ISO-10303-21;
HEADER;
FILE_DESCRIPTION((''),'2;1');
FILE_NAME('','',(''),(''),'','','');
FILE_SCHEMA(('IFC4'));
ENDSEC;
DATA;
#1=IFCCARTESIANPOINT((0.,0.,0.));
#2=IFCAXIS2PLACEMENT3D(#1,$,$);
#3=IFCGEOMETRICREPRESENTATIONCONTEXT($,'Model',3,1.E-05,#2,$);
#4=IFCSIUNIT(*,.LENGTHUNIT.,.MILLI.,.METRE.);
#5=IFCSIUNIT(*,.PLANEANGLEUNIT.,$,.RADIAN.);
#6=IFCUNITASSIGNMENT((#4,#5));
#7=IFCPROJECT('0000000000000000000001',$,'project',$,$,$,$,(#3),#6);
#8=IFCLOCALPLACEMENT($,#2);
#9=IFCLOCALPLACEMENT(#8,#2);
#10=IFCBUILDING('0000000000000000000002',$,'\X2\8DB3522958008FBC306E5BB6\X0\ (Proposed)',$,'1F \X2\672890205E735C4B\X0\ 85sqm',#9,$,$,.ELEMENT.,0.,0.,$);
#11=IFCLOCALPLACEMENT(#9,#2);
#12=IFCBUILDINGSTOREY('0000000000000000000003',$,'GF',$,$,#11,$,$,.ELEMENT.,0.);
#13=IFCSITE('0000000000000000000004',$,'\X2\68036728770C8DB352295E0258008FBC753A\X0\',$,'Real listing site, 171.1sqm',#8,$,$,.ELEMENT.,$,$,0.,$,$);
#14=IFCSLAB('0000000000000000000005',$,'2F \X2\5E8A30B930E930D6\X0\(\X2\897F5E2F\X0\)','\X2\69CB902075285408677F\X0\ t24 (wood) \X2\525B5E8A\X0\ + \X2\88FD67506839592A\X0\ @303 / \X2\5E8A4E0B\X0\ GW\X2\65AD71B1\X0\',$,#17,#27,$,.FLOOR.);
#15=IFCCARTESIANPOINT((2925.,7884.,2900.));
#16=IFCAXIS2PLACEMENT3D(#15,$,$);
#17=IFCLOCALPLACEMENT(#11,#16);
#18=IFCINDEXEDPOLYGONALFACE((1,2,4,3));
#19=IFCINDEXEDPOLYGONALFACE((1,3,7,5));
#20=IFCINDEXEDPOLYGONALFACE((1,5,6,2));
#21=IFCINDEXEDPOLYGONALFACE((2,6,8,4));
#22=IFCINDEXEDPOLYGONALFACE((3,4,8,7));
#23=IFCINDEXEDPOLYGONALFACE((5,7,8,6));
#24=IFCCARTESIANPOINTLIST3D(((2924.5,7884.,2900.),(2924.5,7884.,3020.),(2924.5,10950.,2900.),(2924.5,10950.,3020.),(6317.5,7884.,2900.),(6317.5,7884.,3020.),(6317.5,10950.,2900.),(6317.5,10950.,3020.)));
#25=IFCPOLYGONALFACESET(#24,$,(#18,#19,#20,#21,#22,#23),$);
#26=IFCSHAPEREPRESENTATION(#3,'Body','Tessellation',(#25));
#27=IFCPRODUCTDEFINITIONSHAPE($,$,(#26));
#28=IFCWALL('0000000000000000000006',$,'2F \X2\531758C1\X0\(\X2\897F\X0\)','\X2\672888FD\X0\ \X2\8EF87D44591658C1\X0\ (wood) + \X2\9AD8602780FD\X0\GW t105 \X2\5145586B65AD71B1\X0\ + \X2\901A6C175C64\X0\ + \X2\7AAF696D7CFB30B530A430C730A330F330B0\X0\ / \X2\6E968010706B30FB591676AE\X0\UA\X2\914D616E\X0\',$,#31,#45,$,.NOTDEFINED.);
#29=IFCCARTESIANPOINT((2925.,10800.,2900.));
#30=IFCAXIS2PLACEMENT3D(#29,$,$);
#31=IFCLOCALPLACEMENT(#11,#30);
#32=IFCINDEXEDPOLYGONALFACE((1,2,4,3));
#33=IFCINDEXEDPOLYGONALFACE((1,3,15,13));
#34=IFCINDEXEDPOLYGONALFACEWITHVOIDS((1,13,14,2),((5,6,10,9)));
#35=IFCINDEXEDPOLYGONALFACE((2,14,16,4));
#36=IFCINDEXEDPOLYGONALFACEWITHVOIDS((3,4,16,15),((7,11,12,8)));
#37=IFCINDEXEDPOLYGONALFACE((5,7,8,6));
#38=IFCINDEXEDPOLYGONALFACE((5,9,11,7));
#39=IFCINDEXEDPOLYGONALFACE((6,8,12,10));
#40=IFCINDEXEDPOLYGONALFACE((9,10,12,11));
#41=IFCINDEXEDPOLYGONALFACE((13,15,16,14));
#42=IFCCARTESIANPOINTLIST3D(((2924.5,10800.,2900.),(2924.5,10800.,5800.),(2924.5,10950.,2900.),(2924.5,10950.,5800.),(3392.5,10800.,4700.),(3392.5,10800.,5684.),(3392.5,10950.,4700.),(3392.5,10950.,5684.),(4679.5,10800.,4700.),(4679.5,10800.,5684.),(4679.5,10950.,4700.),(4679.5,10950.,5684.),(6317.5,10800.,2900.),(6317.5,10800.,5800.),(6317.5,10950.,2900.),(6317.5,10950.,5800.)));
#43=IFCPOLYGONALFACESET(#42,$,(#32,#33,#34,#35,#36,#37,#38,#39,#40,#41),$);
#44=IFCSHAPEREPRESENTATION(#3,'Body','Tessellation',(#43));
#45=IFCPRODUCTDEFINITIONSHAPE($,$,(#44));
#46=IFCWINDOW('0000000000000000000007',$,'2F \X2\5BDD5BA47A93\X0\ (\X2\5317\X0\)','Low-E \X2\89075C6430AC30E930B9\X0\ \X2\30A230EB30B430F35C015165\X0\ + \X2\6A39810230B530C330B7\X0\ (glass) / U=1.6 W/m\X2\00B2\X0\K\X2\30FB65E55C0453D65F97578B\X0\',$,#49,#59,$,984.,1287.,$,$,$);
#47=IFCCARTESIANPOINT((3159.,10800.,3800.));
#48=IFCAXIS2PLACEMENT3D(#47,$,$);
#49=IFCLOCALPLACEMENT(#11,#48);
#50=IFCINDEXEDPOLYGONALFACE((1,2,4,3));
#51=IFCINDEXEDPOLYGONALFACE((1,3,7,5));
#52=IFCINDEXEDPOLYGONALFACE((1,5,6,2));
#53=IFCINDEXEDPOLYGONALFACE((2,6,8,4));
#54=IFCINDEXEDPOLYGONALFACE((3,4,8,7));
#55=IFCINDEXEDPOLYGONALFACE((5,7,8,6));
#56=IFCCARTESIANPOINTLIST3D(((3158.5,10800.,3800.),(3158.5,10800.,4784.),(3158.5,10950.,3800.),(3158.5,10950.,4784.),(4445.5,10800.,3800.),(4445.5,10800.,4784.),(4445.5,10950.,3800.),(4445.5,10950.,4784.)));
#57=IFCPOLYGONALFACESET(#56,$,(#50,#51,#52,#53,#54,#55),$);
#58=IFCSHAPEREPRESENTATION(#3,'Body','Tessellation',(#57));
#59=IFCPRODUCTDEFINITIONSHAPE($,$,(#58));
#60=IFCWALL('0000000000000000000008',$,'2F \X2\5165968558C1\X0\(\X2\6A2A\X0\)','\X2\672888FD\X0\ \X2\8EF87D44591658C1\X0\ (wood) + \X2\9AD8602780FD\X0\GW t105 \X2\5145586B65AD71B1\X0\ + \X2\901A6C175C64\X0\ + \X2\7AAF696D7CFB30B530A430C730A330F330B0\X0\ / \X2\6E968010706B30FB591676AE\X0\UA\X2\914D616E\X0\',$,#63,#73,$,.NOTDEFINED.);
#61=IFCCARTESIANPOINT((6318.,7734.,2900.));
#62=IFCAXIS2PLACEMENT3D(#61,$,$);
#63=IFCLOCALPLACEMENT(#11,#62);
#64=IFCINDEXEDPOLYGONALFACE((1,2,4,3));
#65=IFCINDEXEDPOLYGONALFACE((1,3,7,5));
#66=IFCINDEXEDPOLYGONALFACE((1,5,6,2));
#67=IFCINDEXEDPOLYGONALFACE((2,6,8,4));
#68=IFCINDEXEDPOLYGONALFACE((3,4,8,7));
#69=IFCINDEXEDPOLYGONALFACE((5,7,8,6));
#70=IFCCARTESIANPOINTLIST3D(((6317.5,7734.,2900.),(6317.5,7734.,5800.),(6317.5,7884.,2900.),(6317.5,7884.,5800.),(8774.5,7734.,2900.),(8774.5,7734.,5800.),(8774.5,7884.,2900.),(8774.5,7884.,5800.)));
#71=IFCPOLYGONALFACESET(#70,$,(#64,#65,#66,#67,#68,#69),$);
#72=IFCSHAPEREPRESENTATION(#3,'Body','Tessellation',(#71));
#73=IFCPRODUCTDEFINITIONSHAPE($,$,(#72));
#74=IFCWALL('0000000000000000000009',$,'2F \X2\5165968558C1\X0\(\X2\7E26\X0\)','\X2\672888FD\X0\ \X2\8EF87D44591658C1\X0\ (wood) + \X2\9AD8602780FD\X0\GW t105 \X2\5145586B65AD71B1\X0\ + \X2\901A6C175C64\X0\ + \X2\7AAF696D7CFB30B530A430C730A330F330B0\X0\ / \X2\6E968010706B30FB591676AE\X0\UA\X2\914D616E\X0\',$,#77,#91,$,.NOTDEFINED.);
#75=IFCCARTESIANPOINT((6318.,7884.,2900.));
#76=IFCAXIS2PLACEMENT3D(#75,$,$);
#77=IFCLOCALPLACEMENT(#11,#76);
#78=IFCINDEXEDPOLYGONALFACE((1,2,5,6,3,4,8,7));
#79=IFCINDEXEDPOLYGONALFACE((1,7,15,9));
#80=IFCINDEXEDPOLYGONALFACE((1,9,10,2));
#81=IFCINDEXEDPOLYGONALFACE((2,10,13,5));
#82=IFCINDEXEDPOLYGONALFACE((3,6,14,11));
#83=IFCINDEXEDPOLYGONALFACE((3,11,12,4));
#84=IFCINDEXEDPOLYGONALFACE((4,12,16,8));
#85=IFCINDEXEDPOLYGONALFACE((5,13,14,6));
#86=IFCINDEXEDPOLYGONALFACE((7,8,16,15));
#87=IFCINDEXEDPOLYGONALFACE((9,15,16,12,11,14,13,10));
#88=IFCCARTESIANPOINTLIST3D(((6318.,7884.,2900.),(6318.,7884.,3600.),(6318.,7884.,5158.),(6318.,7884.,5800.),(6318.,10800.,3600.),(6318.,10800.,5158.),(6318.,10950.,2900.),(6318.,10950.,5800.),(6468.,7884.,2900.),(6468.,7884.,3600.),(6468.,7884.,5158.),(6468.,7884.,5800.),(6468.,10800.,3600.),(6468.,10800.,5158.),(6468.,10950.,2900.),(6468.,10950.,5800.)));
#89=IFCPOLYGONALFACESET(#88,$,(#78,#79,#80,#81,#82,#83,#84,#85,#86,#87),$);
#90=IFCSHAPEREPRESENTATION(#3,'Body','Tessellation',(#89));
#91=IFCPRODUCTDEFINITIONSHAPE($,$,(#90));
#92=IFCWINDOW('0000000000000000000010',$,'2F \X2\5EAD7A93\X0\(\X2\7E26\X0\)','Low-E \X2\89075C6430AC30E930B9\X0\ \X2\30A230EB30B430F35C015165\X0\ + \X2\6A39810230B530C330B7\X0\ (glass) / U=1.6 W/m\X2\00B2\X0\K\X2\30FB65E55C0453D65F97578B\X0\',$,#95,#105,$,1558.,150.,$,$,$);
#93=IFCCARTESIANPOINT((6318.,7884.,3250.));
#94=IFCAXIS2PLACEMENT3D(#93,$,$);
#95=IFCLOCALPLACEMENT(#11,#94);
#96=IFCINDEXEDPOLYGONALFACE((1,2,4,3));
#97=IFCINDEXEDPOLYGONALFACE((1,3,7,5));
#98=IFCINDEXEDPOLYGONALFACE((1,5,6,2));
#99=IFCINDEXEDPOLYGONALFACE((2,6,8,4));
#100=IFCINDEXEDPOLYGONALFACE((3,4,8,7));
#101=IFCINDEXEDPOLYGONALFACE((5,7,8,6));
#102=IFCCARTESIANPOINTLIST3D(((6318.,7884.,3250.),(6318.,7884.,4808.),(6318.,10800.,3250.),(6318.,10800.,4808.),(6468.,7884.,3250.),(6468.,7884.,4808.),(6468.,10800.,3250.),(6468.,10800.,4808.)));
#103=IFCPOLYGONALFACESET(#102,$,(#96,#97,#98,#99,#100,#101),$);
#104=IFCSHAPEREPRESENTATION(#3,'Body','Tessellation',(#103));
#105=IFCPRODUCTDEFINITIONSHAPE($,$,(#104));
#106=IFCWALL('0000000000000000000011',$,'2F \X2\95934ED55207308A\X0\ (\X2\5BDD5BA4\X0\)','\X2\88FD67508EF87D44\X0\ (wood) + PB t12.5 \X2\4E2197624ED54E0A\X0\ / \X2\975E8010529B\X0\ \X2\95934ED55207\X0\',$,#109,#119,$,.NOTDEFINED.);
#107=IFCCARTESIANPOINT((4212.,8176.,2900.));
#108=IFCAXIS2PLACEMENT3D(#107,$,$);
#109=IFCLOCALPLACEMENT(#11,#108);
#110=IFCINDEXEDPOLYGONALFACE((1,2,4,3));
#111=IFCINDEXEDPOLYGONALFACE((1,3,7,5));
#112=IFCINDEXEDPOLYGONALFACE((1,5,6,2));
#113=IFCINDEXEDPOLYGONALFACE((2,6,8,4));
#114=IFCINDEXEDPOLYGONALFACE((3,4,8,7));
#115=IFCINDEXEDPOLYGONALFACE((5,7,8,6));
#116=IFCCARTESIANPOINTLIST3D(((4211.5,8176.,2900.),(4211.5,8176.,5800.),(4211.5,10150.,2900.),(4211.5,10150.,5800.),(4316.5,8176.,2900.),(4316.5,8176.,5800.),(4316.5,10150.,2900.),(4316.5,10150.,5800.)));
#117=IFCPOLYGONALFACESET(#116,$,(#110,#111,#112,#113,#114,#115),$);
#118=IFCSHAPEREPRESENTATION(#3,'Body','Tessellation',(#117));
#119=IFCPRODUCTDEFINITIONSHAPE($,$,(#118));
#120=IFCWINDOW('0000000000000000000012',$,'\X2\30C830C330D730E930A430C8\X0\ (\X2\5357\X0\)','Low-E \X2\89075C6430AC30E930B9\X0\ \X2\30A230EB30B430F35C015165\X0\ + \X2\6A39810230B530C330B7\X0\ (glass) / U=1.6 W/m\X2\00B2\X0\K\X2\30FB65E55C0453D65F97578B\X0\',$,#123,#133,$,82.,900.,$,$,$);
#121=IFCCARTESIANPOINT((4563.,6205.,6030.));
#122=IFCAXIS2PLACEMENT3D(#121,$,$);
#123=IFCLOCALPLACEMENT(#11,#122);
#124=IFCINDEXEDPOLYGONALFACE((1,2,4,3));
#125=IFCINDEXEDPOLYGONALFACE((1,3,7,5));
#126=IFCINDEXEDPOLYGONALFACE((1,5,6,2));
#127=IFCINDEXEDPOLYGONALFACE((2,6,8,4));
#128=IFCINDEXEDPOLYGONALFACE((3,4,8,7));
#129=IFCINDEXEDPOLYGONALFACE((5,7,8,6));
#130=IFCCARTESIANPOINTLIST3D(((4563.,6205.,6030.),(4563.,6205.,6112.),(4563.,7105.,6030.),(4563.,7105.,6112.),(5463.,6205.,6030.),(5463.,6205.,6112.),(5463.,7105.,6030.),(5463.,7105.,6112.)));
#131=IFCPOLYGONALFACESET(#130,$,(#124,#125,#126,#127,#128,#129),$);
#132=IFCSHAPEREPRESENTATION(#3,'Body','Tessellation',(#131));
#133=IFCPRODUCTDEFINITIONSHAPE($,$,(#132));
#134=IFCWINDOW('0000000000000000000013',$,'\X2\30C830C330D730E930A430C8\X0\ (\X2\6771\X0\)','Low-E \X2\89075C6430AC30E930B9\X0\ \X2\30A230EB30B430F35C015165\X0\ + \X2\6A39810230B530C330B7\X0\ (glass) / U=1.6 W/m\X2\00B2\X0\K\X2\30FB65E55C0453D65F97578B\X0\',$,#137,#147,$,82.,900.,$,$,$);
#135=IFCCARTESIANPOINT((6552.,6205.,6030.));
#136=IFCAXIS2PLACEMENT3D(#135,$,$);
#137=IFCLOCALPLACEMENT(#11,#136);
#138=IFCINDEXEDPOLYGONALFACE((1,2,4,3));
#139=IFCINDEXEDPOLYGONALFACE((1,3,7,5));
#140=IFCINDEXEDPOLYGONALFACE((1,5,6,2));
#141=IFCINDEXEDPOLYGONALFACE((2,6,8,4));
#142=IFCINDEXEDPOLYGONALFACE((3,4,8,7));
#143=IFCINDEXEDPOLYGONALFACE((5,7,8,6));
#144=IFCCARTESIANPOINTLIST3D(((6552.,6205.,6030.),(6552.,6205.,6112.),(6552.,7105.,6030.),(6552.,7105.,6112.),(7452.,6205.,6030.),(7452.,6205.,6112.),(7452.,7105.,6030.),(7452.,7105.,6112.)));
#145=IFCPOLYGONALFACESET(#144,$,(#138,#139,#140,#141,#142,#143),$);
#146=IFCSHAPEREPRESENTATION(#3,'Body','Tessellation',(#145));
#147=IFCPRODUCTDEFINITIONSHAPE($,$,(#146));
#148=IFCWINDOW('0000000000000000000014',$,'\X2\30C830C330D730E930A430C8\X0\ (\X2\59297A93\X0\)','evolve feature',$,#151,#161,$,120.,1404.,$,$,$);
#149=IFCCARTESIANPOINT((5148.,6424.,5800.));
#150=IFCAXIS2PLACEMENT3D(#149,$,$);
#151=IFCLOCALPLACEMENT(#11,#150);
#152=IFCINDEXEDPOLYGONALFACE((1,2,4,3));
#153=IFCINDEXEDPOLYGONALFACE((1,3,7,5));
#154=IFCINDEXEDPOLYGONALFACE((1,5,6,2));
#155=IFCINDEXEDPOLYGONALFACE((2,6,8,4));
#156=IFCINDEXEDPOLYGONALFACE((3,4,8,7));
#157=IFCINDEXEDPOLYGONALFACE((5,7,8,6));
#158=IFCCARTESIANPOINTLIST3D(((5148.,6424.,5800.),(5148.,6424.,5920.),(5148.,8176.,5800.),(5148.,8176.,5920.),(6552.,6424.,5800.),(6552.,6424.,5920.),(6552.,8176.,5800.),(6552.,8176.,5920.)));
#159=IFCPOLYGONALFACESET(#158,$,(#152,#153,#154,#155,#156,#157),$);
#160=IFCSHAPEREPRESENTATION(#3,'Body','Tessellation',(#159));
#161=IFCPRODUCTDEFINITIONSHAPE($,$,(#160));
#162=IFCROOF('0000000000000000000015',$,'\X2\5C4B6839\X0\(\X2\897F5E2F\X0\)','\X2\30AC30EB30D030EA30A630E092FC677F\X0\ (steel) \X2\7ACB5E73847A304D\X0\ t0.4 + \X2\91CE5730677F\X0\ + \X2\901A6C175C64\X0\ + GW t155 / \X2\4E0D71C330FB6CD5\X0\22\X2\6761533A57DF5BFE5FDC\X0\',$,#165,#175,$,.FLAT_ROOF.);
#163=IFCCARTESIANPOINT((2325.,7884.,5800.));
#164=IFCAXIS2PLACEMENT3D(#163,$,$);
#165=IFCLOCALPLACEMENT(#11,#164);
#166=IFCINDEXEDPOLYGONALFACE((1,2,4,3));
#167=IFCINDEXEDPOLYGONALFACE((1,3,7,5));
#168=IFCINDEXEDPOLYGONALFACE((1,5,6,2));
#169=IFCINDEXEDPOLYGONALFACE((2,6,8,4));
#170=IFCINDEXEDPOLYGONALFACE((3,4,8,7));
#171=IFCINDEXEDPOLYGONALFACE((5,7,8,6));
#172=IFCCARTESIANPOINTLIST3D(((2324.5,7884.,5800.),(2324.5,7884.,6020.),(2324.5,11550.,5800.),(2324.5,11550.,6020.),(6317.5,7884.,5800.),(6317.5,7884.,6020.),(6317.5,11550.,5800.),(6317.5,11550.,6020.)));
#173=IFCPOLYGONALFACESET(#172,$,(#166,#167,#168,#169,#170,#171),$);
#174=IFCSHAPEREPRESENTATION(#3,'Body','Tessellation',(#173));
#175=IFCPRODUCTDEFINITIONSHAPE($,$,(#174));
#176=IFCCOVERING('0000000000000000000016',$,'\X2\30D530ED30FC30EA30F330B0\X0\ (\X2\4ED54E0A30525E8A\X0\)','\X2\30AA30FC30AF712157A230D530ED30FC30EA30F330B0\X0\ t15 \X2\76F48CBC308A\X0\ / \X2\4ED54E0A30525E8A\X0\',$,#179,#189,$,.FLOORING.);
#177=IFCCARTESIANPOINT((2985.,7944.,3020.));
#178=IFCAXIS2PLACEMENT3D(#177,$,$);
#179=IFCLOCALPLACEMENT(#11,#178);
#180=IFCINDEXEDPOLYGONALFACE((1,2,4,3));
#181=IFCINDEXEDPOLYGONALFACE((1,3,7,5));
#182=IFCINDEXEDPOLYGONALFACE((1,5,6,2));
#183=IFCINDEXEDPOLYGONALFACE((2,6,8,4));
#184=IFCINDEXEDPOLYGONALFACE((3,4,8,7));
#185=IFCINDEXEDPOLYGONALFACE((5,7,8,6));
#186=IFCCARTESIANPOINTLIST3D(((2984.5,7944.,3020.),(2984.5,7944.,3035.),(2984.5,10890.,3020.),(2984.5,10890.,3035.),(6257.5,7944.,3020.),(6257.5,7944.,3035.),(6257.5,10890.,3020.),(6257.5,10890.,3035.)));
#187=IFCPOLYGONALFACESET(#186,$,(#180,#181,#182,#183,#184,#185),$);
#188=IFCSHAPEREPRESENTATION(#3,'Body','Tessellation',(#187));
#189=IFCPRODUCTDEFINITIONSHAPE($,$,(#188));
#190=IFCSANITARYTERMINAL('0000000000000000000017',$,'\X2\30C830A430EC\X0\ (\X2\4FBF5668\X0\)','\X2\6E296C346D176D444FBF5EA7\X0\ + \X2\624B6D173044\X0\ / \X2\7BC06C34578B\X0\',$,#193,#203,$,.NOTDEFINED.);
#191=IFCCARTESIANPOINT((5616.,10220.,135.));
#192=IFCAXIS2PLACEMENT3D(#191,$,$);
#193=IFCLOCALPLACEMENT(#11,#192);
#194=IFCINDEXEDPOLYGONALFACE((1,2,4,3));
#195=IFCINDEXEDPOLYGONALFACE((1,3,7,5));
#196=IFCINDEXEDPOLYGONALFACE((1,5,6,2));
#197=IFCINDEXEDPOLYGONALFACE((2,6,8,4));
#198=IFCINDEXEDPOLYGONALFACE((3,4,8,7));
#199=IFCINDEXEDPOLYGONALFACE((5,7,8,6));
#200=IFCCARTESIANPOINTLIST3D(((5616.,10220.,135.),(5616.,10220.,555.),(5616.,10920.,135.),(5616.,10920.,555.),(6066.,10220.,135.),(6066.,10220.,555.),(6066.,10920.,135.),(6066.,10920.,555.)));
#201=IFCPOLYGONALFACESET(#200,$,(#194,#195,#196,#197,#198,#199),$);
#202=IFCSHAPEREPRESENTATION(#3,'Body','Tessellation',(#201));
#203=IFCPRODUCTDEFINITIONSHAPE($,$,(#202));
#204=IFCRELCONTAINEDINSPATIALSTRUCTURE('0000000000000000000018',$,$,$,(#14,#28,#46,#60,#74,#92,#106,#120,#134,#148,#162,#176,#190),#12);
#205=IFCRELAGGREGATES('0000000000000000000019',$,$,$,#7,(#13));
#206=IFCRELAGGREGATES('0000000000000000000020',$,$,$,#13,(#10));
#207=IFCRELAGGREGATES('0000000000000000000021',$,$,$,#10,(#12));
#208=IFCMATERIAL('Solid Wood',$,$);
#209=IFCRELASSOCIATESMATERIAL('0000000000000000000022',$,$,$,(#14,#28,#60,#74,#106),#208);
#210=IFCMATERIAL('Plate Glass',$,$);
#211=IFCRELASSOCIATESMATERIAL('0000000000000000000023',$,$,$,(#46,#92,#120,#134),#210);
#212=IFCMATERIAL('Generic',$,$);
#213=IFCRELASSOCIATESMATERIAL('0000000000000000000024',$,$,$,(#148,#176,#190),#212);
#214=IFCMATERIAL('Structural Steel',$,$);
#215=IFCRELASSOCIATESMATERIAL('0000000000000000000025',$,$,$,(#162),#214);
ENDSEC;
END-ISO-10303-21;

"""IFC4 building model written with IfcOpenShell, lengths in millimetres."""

from ifc_helpers import new_model, si_unit, frame, frame_2d, origin, place, context, project, spatial, rectangle, extrude, material, element, fill, save


model = new_model("IFC4")

# Units and contexts
model_context = context("Model", 3, precision=1e-05, world=origin())
ifc_project = project(units=[si_unit("LENGTHUNIT", "METRE", prefix="MILLI"), si_unit("PLANEANGLEUNIT", "RADIAN")], contexts=[model_context])

# Site, building, storey
site_placement = place(None, origin())
site = spatial("IfcSite", under=ifc_project, at=site_placement, Name="栃木県足利市堀込町", ObjectType="Real listing site, 171.1sqm", CompositionType="ELEMENT", RefElevation=0.0)
building_placement = place(site_placement, origin())
building = spatial("IfcBuilding", under=site, at=building_placement, Name="足利堀込の家 (Proposed)", ObjectType="1F 木造平屋 85sqm", CompositionType="ELEMENT", ElevationOfRefHeight=0.0, ElevationOfTerrain=0.0)
storey_placement = place(building_placement, origin())
storey = spatial("IfcBuildingStorey", under=building, at=storey_placement, Name="GF", CompositionType="ELEMENT", Elevation=0.0)

# Slab
ifc_material_1 = material(Name="Solid Wood")
slab_placement = place(storey_placement, frame((2925.0, 7884.0, 2900.0)))
element("IfcSlab", 1, at=slab_placement, inside=storey, material=ifc_material_1, Name="2F 床スラブ(西帯)", Description="構造用合板 t24 (wood) 剛床 + 製材根太 @303 / 床下 GW断熱", PredefinedType="FLOOR", context=model_context, shape_type="SweptSolid", body=[
    extrude(rectangle(XDim=3393.0, YDim=3066.0, at=frame_2d((1696.0, 1533.0))), frame((2925.0, 7884.0, 2900.0)), (0.0, 0.0, 1.0), 120.0),
])

# Wall, opening, window
wall_1_placement = place(storey_placement, frame((2925.0, 10800.0, 2900.0)))
wall_1 = element("IfcWall", 2, at=wall_1_placement, inside=storey, material=ifc_material_1, Name="2F 北壁(西)", Description="木製 軸組外壁 (wood) + 高性能GW t105 充填断熱 + 通気層 + 窯業系サイディング / 準耐火・外皮UA配慮", PredefinedType="NOTDEFINED", context=model_context, shape_type="SweptSolid", body=[
    extrude(rectangle(XDim=3393.0, YDim=150.0, at=frame_2d((1696.0, 75.0))), frame((2925.0, 10800.0, 2900.0)), (0.0, 0.0, 1.0), 2900.0),
])
opening_1_placement = place(storey_placement, frame((3159.0, 10800.0, 3800.0)))
opening_1 = element("IfcOpeningElement", 3, at=opening_1_placement, cuts=wall_1, PredefinedType="NOTDEFINED", context=model_context, shape_type="SweptSolid", body=[
    extrude(rectangle(XDim=1287.0, YDim=150.0, at=frame_2d((643.0, 75.0))), frame((3159.0, 10800.0, 3800.0)), (0.0, 0.0, 1.0), 984.0),
])
ifc_material_2 = material(Name="Plate Glass")
window_1_placement = place(storey_placement, frame((3159.0, 10800.0, 3800.0)))
window_1 = element("IfcWindow", 4, at=window_1_placement, inside=storey, material=ifc_material_2, Name="2F 寝室窓 (北)", Description="Low-E 複層ガラス アルゴン封入 + 樹脂サッシ (glass) / U=1.6 W/m²K・日射取得型", OverallHeight=984.0, OverallWidth=1287.0, context=model_context, shape_type="SweptSolid", body=[
    extrude(rectangle(XDim=1287.0, YDim=150.0, at=frame_2d((643.0, 75.0))), frame((3159.0, 10800.0, 3800.0)), (0.0, 0.0, 1.0), 984.0),
])
fill(opening_1, window_1)

# Wall
wall_2_placement = place(storey_placement, frame((6318.0, 7734.0, 2900.0)))
element("IfcWall", 5, at=wall_2_placement, inside=storey, material=ifc_material_1, Name="2F 入隅壁(横)", Description="木製 軸組外壁 (wood) + 高性能GW t105 充填断熱 + 通気層 + 窯業系サイディング / 準耐火・外皮UA配慮", PredefinedType="NOTDEFINED", context=model_context, shape_type="SweptSolid", body=[
    extrude(rectangle(XDim=2457.0, YDim=150.0, at=frame_2d((1228.0, 75.0))), frame((6318.0, 7734.0, 2900.0)), (0.0, 0.0, 1.0), 2900.0),
])

# Wall, opening, window
wall_3_placement = place(storey_placement, frame((6318.0, 7884.0, 2900.0)))
wall_3 = element("IfcWall", 6, at=wall_3_placement, inside=storey, material=ifc_material_1, Name="2F 入隅壁(縦)", Description="木製 軸組外壁 (wood) + 高性能GW t105 充填断熱 + 通気層 + 窯業系サイディング / 準耐火・外皮UA配慮", PredefinedType="NOTDEFINED", context=model_context, shape_type="SweptSolid", body=[
    extrude(rectangle(XDim=150.0, YDim=3066.0, at=frame_2d((75.0, 1533.0))), frame((6318.0, 7884.0, 2900.0)), (0.0, 0.0, 1.0), 2900.0),
])
opening_2_placement = place(storey_placement, frame((6318.0, 7884.0, 3250.0)))
opening_2 = element("IfcOpeningElement", 7, at=opening_2_placement, cuts=wall_3, PredefinedType="NOTDEFINED", context=model_context, shape_type="SweptSolid", body=[
    extrude(rectangle(XDim=150.0, YDim=2916.0, at=frame_2d((75.0, 1458.0))), frame((6318.0, 7884.0, 3250.0)), (0.0, 0.0, 1.0), 1558.0),
])
window_2_placement = place(storey_placement, frame((6318.0, 7884.0, 3250.0)))
window_2 = element("IfcWindow", 8, at=window_2_placement, inside=storey, material=ifc_material_2, Name="2F 庭窓(縦)", Description="Low-E 複層ガラス アルゴン封入 + 樹脂サッシ (glass) / U=1.6 W/m²K・日射取得型", OverallHeight=1558.0, OverallWidth=150.0, context=model_context, shape_type="SweptSolid", body=[
    extrude(rectangle(XDim=150.0, YDim=2916.0, at=frame_2d((75.0, 1458.0))), frame((6318.0, 7884.0, 3250.0)), (0.0, 0.0, 1.0), 1558.0),
])
fill(opening_2, window_2)

# Wall
wall_4_placement = place(storey_placement, frame((4212.0, 8176.0, 2900.0)))
element("IfcWall", 9, at=wall_4_placement, inside=storey, material=ifc_material_1, Name="2F 間仕切り (寝室)", Description="製材軸組 (wood) + PB t12.5 両面仕上 / 非耐力 間仕切", PredefinedType="NOTDEFINED", context=model_context, shape_type="SweptSolid", body=[
    extrude(rectangle(XDim=105.0, YDim=1974.0, at=frame_2d((52.0, 987.0))), frame((4212.0, 8176.0, 2900.0)), (0.0, 0.0, 1.0), 2900.0),
])

# Windows
window_3_placement = place(storey_placement, frame((4563.0, 6205.0, 6030.0)))
element("IfcWindow", 10, at=window_3_placement, inside=storey, material=ifc_material_2, Name="トップライト (南)", Description="Low-E 複層ガラス アルゴン封入 + 樹脂サッシ (glass) / U=1.6 W/m²K・日射取得型", OverallHeight=82.0, OverallWidth=900.0, context=model_context, shape_type="SweptSolid", body=[
    extrude(rectangle(XDim=900.0, YDim=900.0, at=frame_2d((450.0, 450.0))), frame((4563.0, 6205.0, 6030.0)), (0.0, 0.0, 1.0), 82.0),
])
window_4_placement = place(storey_placement, frame((6552.0, 6205.0, 6030.0)))
element("IfcWindow", 11, at=window_4_placement, inside=storey, material=ifc_material_2, Name="トップライト (東)", Description="Low-E 複層ガラス アルゴン封入 + 樹脂サッシ (glass) / U=1.6 W/m²K・日射取得型", OverallHeight=82.0, OverallWidth=900.0, context=model_context, shape_type="SweptSolid", body=[
    extrude(rectangle(XDim=900.0, YDim=900.0, at=frame_2d((450.0, 450.0))), frame((6552.0, 6205.0, 6030.0)), (0.0, 0.0, 1.0), 82.0),
])
ifc_material_3 = material(Name="Generic")
window_5_placement = place(storey_placement, frame((5148.0, 6424.0, 5800.0)))
element("IfcWindow", 12, at=window_5_placement, inside=storey, material=ifc_material_3, Name="トップライト (天窓)", Description="evolve feature", OverallHeight=120.0, OverallWidth=1404.0, context=model_context, shape_type="SweptSolid", body=[
    extrude(rectangle(XDim=1404.0, YDim=1752.0, at=frame_2d((702.0, 876.0))), frame((5148.0, 6424.0, 5800.0)), (0.0, 0.0, 1.0), 120.0),
])

# Roof
ifc_material_4 = material(Name="Structural Steel")
for number, where, name in (
    (13, (2325.0, 7884.0, 5800.0), "屋根(西帯)"),
):
    element("IfcRoof", number, at=place(storey_placement, frame(where)), inside=storey, material=ifc_material_4, Name=name, Description="ガルバリウム鋼板 (steel) 立平葺き t0.4 + 野地板 + 通気層 + GW t155 / 不燃・法22条区域対応", PredefinedType="FLAT_ROOF", context=model_context, shape_type="SweptSolid", body=[
        extrude(rectangle(XDim=3993.0, YDim=3666.0, at=frame_2d((1996.0, 1833.0))), frame((2325.0, 7884.0, 5800.0)), (0.0, 0.0, 1.0), 220.0),
    ])

# Covering
covering_placement = place(storey_placement, frame((2985.0, 7944.0, 3020.0)))
element("IfcCovering", 14, at=covering_placement, inside=storey, material=ifc_material_3, Name="フローリング (仕上げ床)", Description="オーク無垢フローリング t15 直貼り / 仕上げ床", PredefinedType="FLOORING", context=model_context, shape_type="SweptSolid", body=[
    extrude(rectangle(XDim=3273.0, YDim=2946.0, at=frame_2d((1636.0, 1473.0))), frame((2985.0, 7944.0, 3020.0)), (0.0, 0.0, 1.0), 15.0),
])

# Sanitary terminal
sanitary_terminal_placement = place(storey_placement, frame((5616.0, 10220.0, 135.0)))
element("IfcSanitaryTerminal", 15, at=sanitary_terminal_placement, inside=storey, material=ifc_material_3, Name="トイレ (便器)", Description="温水洗浄便座 + 手洗い / 節水型", PredefinedType="NOTDEFINED", context=model_context, shape_type="SweptSolid", body=[
    extrude(rectangle(XDim=450.0, YDim=700.0, at=frame_2d((225.0, 350.0))), frame((5616.0, 10220.0, 135.0)), (0.0, 0.0, 1.0), 420.0),
])

save(model, "model.ifc")
